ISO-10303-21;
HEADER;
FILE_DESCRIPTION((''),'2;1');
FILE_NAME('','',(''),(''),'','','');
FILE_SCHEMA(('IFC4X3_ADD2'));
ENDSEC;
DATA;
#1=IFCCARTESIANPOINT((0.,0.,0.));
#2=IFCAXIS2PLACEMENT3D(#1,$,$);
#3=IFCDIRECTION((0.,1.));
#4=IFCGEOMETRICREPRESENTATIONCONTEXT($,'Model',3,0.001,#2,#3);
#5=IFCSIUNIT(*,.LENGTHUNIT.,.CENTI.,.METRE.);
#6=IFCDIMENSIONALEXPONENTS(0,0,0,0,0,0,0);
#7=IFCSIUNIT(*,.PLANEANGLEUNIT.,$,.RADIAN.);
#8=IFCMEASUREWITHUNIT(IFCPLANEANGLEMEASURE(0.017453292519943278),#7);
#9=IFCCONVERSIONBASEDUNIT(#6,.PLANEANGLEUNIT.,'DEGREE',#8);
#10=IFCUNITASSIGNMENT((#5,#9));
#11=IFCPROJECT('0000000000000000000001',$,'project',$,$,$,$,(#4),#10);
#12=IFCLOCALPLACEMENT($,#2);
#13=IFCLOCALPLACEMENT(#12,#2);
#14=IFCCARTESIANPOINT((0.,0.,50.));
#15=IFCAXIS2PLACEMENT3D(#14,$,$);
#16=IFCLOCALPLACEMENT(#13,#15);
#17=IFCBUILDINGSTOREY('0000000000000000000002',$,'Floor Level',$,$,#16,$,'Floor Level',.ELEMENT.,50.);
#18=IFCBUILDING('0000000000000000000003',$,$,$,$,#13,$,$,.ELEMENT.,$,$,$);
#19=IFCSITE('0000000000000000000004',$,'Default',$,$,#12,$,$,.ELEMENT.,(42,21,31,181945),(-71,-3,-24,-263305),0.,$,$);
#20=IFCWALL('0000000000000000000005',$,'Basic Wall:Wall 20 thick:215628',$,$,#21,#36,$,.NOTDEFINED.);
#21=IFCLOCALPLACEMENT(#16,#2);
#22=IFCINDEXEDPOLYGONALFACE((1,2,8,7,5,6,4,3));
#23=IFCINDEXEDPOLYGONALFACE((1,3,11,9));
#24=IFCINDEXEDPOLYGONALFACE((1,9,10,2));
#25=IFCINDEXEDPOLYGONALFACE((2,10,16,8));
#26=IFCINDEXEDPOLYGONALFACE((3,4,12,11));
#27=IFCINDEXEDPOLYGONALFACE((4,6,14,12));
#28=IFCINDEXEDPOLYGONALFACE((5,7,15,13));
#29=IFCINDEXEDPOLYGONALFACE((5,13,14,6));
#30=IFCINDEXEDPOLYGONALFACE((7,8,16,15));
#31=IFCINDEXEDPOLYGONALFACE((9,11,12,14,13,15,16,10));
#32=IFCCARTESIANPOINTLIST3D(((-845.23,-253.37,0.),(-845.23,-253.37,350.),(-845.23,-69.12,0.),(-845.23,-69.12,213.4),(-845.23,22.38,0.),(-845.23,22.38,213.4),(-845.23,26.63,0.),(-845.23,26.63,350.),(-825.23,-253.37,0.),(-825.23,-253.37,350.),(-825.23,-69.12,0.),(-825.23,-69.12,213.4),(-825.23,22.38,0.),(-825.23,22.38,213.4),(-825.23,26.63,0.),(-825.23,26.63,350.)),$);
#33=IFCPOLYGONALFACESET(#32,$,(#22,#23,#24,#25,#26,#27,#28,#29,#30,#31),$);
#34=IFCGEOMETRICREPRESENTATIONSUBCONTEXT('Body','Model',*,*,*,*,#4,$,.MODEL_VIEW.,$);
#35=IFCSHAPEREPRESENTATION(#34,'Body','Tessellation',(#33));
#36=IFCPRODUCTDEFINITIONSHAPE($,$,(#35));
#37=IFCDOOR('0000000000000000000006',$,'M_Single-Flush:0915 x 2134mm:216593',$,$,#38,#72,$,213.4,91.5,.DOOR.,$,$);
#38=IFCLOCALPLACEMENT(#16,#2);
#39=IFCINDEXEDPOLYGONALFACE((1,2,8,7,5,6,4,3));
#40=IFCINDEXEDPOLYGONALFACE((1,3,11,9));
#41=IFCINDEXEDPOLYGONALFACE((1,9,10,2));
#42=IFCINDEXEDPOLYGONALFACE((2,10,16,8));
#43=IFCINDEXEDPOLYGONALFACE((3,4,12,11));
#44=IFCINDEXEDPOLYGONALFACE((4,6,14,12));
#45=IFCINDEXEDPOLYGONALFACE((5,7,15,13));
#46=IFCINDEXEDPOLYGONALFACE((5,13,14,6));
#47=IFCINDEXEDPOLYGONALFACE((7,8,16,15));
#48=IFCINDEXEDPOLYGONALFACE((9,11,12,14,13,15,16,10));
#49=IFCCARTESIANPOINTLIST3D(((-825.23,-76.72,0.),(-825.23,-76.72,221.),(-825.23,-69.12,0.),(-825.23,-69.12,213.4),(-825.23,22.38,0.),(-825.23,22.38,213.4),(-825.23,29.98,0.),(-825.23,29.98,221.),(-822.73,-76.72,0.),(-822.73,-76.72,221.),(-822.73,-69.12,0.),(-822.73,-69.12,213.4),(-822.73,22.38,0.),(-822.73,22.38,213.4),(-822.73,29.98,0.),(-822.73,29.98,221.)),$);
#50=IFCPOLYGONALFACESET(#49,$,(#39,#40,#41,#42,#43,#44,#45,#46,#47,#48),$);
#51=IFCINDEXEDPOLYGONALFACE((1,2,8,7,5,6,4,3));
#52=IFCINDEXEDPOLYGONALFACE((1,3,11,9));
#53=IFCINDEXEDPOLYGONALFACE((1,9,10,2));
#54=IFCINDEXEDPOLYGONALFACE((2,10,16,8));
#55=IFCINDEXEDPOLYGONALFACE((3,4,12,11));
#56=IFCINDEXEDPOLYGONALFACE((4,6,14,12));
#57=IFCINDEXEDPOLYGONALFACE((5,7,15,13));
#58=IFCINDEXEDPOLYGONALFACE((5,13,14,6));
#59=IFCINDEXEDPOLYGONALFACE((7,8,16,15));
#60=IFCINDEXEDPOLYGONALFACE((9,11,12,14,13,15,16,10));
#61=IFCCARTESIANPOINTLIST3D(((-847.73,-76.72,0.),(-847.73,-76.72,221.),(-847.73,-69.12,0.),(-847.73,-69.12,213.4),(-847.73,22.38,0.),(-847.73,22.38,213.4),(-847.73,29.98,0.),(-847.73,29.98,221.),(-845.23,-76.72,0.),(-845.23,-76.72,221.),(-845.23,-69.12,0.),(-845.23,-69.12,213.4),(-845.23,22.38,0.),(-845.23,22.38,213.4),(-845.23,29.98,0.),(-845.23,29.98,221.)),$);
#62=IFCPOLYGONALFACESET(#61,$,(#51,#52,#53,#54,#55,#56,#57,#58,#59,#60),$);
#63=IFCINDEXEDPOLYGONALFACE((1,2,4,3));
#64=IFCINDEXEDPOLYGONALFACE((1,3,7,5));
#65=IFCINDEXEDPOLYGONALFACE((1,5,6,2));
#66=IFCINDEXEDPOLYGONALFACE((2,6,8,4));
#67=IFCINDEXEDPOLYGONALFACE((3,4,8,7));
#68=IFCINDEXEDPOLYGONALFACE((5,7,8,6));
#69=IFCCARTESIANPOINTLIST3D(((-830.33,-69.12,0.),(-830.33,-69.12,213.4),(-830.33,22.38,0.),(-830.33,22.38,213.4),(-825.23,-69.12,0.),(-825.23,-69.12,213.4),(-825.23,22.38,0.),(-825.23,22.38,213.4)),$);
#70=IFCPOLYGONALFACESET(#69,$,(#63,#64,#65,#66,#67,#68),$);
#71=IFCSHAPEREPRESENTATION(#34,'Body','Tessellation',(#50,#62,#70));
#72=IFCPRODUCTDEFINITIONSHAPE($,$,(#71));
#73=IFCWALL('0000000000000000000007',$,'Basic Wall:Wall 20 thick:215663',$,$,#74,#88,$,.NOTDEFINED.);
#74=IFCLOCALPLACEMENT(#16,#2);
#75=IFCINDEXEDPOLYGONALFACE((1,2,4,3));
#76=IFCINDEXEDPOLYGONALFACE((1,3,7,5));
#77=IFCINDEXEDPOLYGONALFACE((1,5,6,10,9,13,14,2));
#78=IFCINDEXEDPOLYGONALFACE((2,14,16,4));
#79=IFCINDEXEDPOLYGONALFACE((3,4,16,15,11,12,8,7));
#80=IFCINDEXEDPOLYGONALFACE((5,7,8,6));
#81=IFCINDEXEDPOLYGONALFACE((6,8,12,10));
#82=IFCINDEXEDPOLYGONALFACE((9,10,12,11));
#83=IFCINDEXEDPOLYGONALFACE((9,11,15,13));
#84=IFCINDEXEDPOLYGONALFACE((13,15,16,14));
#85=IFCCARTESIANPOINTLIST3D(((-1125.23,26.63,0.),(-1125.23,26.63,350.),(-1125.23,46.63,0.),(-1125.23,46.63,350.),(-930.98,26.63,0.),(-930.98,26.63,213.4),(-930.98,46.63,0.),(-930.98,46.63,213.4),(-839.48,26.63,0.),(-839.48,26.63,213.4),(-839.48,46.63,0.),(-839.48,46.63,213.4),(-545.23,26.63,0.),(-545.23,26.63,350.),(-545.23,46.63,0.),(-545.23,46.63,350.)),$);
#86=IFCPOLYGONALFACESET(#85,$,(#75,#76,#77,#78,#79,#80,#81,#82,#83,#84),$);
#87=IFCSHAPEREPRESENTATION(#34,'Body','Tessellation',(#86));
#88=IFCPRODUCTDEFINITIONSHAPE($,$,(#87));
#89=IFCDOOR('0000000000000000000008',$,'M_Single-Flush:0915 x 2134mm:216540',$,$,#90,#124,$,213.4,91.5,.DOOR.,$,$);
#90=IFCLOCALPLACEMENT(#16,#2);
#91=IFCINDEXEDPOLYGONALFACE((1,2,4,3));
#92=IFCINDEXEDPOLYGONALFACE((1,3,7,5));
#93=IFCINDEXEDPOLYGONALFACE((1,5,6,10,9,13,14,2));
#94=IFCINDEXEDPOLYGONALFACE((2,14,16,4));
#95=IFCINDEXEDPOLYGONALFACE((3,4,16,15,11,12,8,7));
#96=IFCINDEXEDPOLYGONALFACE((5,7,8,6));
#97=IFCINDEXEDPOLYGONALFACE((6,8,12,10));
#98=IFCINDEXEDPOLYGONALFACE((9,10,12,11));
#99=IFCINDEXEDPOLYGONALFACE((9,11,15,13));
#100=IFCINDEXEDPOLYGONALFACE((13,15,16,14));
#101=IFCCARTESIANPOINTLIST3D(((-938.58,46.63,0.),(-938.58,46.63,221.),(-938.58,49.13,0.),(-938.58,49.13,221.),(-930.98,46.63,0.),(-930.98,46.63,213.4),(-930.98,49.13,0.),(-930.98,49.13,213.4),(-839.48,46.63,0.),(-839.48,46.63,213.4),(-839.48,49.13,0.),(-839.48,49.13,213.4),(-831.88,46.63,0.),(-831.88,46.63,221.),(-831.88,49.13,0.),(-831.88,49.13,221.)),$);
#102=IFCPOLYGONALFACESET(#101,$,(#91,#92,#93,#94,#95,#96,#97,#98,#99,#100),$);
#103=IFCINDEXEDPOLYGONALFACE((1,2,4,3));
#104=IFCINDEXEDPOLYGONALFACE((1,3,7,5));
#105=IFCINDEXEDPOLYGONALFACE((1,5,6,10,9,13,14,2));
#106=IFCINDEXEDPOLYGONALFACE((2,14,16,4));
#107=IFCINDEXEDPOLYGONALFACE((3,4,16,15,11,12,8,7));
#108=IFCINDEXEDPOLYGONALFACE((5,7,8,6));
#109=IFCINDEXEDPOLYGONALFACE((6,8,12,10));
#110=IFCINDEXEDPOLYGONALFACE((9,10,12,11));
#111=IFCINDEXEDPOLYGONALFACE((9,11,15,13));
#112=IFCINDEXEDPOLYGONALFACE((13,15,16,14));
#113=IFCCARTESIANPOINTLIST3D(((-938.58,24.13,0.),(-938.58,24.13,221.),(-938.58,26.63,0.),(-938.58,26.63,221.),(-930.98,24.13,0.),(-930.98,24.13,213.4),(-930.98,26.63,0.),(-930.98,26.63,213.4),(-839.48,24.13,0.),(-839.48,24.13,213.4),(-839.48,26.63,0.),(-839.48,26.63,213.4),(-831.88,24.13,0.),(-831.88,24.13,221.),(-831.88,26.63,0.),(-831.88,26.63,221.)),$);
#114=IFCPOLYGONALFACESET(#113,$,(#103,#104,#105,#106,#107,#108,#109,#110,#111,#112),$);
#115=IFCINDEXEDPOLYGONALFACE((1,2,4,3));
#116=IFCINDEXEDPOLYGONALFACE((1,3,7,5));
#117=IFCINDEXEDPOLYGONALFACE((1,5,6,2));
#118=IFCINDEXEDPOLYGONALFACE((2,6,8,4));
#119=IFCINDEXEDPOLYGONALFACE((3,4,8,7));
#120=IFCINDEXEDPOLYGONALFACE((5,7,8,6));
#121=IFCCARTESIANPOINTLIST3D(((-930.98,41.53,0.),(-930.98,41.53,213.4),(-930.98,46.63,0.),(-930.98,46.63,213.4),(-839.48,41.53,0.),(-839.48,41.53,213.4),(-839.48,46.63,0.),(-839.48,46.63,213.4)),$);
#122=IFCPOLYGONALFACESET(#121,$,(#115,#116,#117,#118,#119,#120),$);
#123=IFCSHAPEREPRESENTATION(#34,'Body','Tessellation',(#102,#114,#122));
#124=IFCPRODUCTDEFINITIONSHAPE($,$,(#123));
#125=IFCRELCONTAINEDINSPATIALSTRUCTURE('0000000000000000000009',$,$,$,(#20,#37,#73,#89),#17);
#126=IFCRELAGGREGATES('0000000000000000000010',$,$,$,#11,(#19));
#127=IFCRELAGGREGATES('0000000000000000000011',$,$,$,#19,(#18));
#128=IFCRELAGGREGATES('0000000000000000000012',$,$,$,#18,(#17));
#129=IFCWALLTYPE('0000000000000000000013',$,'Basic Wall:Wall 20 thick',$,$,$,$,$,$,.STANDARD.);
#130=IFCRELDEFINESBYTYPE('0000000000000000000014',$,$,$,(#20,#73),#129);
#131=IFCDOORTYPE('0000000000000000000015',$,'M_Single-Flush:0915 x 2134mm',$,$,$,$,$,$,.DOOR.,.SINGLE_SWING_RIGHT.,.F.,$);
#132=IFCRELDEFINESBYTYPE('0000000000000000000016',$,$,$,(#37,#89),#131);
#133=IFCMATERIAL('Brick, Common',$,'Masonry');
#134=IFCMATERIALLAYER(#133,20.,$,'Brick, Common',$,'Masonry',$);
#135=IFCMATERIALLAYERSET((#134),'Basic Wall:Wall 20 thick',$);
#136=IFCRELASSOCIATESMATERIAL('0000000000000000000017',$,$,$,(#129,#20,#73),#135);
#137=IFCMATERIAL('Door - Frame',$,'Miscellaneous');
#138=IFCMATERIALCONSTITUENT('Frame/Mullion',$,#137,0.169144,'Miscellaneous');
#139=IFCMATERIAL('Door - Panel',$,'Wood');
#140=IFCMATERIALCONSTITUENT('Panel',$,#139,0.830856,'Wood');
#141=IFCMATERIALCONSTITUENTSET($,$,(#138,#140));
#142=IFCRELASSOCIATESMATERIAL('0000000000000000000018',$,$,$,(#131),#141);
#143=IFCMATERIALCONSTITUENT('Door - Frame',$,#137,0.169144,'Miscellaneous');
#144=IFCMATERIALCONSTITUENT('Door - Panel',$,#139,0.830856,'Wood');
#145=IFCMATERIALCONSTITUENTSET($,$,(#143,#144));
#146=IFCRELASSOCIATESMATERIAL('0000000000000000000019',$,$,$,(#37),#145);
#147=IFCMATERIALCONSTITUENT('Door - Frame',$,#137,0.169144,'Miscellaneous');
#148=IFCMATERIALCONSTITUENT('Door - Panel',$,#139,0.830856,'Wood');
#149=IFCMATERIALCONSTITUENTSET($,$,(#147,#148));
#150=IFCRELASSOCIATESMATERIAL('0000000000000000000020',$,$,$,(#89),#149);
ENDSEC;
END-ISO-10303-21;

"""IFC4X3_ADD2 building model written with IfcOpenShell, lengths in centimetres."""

from ifc_helpers import new_model, entity, si_unit, converted_unit, direction, frame, frame_2d, origin, place, context, subcontext, project, spatial, polyline, rectangle, outline, extrude, source, transform, mapped, material, layer, layer_set, constituent, constituent_set, type_object, type_shapes, element, fill, save


model = new_model("IFC4X3_ADD2")

# Units and contexts
model_context = context("Model", 3, precision=0.001, world=origin(), true_north=direction((0.0, 1.0)))
body_context = subcontext(model_context, "Body", "Model", "MODEL_VIEW")
ifc_project = project(units=[si_unit("LENGTHUNIT", "METRE", prefix="CENTI"), converted_unit("PLANEANGLEUNIT", "DEGREE", entity("IfcPlaneAngleMeasure", 0.017453292519943278), si_unit("PLANEANGLEUNIT", "RADIAN"), dimensions=[0, 0, 0, 0, 0, 0, 0])], contexts=[model_context])

# Site, building, storey
site_placement = place(None, origin())
site = spatial("IfcSite", under=ifc_project, at=site_placement, Name="Default", CompositionType="ELEMENT", RefLatitude=(42, 21, 31, 181945), RefLongitude=(-71, -3, -24, -263305), RefElevation=0.0)
building_placement = place(site_placement, origin())
building = spatial("IfcBuilding", under=site, at=building_placement, CompositionType="ELEMENT")
storey_placement = place(building_placement, frame((0.0, 0.0, 50.0)))
storey = spatial("IfcBuildingStorey", under=building, at=storey_placement, Name="Floor Level", LongName="Floor Level", CompositionType="ELEMENT", Elevation=50.0)

# Shared definitions
ifc_material_1 = material(Name="Brick, Common", Category="Masonry")
ifc_layer = layer(ifc_material_1, 20.0, Name="Brick, Common", Category="Masonry")
ifc_layer_set = layer_set([ifc_layer], Name="Basic Wall:Wall 20 thick")
wall_type = type_object("IfcWallType", Name="Basic Wall:Wall 20 thick", PredefinedType="STANDARD", material=ifc_layer_set)

# Shared definitions
ifc_material_2 = material(Name="Door - Frame", Category="Miscellaneous")
ifc_material_3 = material(Name="Door - Panel", Category="Wood")
ifc_constituent_1 = constituent(ifc_material_2, Name="Frame/Mullion", Category="Miscellaneous", fraction=0.169144)
ifc_constituent_2 = constituent(ifc_material_3, Name="Panel", Category="Wood", fraction=0.830856)
ifc_constituent_set_1 = constituent_set(constituents=[ifc_constituent_1, ifc_constituent_2])
door_type = type_object("IfcDoorType", Name="M_Single-Flush:0915 x 2134mm", OperationType="SINGLE_SWING_RIGHT", ParameterTakesPrecedence=False, PredefinedType="DOOR", material=ifc_constituent_set_1)
shared_shape_1 = source(origin(), body_context, "Body", "SweptSolid", [
    extrude(outline(polyline([(-53.35, -112.4), (53.35, -112.4), (53.35, 108.6), (45.75, 108.6), (45.75, -104.8), (-45.75, -104.8), (-45.75, 108.6), (-53.35, 108.6), (-53.35, -112.4)])), frame((45.75, 20.0, 108.6), z_axis=(0.0, 1.0, 0.0), x_axis=(1.0, 0.0, 0.0)), (0.0, 0.0, 1.0), 2.5),
    extrude(outline(polyline([(-112.4, -53.35), (108.6, -53.35), (108.6, -45.75), (-104.8, -45.75), (-104.8, 45.75), (108.6, 45.75), (108.6, 53.35), (-112.4, 53.35), (-112.4, -53.35)])), frame((45.75, -2.5, 108.6), z_axis=(0.0, 1.0, 0.0), x_axis=(0.0, 0.0, -1.0)), (0.0, 0.0, 1.0), 2.5),
    extrude(rectangle(XDim=5.1, YDim=91.5, at=frame_2d((0.0, 0.0), x_axis=(1.0, 0.0))), frame((45.75, 17.45, 0.0), z_axis=(0.0, 0.0, 1.0), x_axis=(0.0, 1.0, 0.0)), (0.0, 0.0, 1.0), 213.4),
])
type_shapes(door_type, [shared_shape_1])

# Walls, openings, doors
wall_1_placement = place(storey_placement, frame((-835.23, -253.37, 0.0), z_axis=(0.0, 0.0, 1.0), x_axis=(0.0, 1.0, 0.0)))
wall_1 = element("IfcWall", 1, at=wall_1_placement, inside=storey, type_object=wall_type, material=ifc_layer_set, Name="Basic Wall:Wall 20 thick:215628", PredefinedType="NOTDEFINED", context=body_context, shape_type="SweptSolid", body=[
    extrude(rectangle(XDim=280.0, YDim=20.0, at=frame_2d((140.0, 0.0), x_axis=(1.0, 0.0))), origin(), (0.0, 0.0, 1.0), 350.0),
])
opening_1_placement = place(wall_1_placement, frame((275.75, 10.0, 0.0)))
opening_1 = element("IfcOpeningElement", 2, at=opening_1_placement, cuts=wall_1, PredefinedType="OPENING", context=body_context, shape_type="SweptSolid", body=[
    extrude(rectangle(XDim=91.5, YDim=213.4, at=frame_2d((106.7, 45.75), x_axis=(0.0, 1.0))), frame((0.0, 0.0, 0.0), z_axis=(0.0, -1.0, 0.0), x_axis=(0.0, 0.0, 1.0)), (0.0, 0.0, 1.0), 20.0),
])
ifc_constituent_3 = constituent(ifc_material_2, Name="Door - Frame", Category="Miscellaneous", fraction=0.169144)
ifc_constituent_4 = constituent(ifc_material_3, Name="Door - Panel", Category="Wood", fraction=0.830856)
ifc_constituent_set_2 = constituent_set(constituents=[ifc_constituent_3, ifc_constituent_4])
door_1_placement = place(opening_1_placement, frame((0.0, 0.0, 0.0), z_axis=(0.0, 0.0, 1.0), x_axis=(-1.0, 0.0, 0.0)))
door_1 = element("IfcDoor", 3, at=door_1_placement, inside=storey, type_object=door_type, material=ifc_constituent_set_2, Name="M_Single-Flush:0915 x 2134mm:216593", OverallHeight=213.4, OverallWidth=91.5, PredefinedType="DOOR", context=body_context, shape_type="MappedRepresentation", body=[
    mapped(shared_shape_1, transform((0.0, 0.0, 0.0), scale=1.0)),
])
fill(opening_1, door_1)
wall_2_placement = place(storey_placement, frame((-545.23, 36.63, 0.0), z_axis=(0.0, 0.0, 1.0), x_axis=(-1.0, 0.0, 0.0)))
wall_2 = element("IfcWall", 4, at=wall_2_placement, inside=storey, type_object=wall_type, material=ifc_layer_set, Name="Basic Wall:Wall 20 thick:215663", PredefinedType="NOTDEFINED", context=body_context, shape_type="SweptSolid", body=[
    extrude(rectangle(XDim=580.0, YDim=20.0, at=frame_2d((290.0, 0.0), x_axis=(1.0, 0.0))), origin(), (0.0, 0.0, 1.0), 350.0),
])
opening_2_placement = place(wall_2_placement, frame((385.75, 10.0, 0.0)))
opening_2 = element("IfcOpeningElement", 5, at=opening_2_placement, cuts=wall_2, PredefinedType="OPENING", context=body_context, shape_type="SweptSolid", body=[
    extrude(rectangle(XDim=91.5, YDim=213.4, at=frame_2d((106.7, 45.75), x_axis=(0.0, 1.0))), frame((0.0, 0.0, 0.0), z_axis=(0.0, -1.0, 0.0), x_axis=(0.0, 0.0, 1.0)), (0.0, 0.0, 1.0), 20.0),
])
ifc_constituent_5 = constituent(ifc_material_2, Name="Door - Frame", Category="Miscellaneous", fraction=0.169144)
ifc_constituent_6 = constituent(ifc_material_3, Name="Door - Panel", Category="Wood", fraction=0.830856)
ifc_constituent_set_3 = constituent_set(constituents=[ifc_constituent_5, ifc_constituent_6])
door_2_placement = place(opening_2_placement, frame((0.0, 0.0, 0.0), z_axis=(0.0, 0.0, 1.0), x_axis=(-1.0, 0.0, 0.0)))
door_2 = element("IfcDoor", 6, at=door_2_placement, inside=storey, type_object=door_type, material=ifc_constituent_set_3, Name="M_Single-Flush:0915 x 2134mm:216540", OverallHeight=213.4, OverallWidth=91.5, PredefinedType="DOOR", context=body_context, shape_type="MappedRepresentation", body=[
    mapped(shared_shape_1, transform((0.0, 0.0, 0.0), scale=1.0)),
])
fill(opening_2, door_2)

save(model, "model.ifc")
